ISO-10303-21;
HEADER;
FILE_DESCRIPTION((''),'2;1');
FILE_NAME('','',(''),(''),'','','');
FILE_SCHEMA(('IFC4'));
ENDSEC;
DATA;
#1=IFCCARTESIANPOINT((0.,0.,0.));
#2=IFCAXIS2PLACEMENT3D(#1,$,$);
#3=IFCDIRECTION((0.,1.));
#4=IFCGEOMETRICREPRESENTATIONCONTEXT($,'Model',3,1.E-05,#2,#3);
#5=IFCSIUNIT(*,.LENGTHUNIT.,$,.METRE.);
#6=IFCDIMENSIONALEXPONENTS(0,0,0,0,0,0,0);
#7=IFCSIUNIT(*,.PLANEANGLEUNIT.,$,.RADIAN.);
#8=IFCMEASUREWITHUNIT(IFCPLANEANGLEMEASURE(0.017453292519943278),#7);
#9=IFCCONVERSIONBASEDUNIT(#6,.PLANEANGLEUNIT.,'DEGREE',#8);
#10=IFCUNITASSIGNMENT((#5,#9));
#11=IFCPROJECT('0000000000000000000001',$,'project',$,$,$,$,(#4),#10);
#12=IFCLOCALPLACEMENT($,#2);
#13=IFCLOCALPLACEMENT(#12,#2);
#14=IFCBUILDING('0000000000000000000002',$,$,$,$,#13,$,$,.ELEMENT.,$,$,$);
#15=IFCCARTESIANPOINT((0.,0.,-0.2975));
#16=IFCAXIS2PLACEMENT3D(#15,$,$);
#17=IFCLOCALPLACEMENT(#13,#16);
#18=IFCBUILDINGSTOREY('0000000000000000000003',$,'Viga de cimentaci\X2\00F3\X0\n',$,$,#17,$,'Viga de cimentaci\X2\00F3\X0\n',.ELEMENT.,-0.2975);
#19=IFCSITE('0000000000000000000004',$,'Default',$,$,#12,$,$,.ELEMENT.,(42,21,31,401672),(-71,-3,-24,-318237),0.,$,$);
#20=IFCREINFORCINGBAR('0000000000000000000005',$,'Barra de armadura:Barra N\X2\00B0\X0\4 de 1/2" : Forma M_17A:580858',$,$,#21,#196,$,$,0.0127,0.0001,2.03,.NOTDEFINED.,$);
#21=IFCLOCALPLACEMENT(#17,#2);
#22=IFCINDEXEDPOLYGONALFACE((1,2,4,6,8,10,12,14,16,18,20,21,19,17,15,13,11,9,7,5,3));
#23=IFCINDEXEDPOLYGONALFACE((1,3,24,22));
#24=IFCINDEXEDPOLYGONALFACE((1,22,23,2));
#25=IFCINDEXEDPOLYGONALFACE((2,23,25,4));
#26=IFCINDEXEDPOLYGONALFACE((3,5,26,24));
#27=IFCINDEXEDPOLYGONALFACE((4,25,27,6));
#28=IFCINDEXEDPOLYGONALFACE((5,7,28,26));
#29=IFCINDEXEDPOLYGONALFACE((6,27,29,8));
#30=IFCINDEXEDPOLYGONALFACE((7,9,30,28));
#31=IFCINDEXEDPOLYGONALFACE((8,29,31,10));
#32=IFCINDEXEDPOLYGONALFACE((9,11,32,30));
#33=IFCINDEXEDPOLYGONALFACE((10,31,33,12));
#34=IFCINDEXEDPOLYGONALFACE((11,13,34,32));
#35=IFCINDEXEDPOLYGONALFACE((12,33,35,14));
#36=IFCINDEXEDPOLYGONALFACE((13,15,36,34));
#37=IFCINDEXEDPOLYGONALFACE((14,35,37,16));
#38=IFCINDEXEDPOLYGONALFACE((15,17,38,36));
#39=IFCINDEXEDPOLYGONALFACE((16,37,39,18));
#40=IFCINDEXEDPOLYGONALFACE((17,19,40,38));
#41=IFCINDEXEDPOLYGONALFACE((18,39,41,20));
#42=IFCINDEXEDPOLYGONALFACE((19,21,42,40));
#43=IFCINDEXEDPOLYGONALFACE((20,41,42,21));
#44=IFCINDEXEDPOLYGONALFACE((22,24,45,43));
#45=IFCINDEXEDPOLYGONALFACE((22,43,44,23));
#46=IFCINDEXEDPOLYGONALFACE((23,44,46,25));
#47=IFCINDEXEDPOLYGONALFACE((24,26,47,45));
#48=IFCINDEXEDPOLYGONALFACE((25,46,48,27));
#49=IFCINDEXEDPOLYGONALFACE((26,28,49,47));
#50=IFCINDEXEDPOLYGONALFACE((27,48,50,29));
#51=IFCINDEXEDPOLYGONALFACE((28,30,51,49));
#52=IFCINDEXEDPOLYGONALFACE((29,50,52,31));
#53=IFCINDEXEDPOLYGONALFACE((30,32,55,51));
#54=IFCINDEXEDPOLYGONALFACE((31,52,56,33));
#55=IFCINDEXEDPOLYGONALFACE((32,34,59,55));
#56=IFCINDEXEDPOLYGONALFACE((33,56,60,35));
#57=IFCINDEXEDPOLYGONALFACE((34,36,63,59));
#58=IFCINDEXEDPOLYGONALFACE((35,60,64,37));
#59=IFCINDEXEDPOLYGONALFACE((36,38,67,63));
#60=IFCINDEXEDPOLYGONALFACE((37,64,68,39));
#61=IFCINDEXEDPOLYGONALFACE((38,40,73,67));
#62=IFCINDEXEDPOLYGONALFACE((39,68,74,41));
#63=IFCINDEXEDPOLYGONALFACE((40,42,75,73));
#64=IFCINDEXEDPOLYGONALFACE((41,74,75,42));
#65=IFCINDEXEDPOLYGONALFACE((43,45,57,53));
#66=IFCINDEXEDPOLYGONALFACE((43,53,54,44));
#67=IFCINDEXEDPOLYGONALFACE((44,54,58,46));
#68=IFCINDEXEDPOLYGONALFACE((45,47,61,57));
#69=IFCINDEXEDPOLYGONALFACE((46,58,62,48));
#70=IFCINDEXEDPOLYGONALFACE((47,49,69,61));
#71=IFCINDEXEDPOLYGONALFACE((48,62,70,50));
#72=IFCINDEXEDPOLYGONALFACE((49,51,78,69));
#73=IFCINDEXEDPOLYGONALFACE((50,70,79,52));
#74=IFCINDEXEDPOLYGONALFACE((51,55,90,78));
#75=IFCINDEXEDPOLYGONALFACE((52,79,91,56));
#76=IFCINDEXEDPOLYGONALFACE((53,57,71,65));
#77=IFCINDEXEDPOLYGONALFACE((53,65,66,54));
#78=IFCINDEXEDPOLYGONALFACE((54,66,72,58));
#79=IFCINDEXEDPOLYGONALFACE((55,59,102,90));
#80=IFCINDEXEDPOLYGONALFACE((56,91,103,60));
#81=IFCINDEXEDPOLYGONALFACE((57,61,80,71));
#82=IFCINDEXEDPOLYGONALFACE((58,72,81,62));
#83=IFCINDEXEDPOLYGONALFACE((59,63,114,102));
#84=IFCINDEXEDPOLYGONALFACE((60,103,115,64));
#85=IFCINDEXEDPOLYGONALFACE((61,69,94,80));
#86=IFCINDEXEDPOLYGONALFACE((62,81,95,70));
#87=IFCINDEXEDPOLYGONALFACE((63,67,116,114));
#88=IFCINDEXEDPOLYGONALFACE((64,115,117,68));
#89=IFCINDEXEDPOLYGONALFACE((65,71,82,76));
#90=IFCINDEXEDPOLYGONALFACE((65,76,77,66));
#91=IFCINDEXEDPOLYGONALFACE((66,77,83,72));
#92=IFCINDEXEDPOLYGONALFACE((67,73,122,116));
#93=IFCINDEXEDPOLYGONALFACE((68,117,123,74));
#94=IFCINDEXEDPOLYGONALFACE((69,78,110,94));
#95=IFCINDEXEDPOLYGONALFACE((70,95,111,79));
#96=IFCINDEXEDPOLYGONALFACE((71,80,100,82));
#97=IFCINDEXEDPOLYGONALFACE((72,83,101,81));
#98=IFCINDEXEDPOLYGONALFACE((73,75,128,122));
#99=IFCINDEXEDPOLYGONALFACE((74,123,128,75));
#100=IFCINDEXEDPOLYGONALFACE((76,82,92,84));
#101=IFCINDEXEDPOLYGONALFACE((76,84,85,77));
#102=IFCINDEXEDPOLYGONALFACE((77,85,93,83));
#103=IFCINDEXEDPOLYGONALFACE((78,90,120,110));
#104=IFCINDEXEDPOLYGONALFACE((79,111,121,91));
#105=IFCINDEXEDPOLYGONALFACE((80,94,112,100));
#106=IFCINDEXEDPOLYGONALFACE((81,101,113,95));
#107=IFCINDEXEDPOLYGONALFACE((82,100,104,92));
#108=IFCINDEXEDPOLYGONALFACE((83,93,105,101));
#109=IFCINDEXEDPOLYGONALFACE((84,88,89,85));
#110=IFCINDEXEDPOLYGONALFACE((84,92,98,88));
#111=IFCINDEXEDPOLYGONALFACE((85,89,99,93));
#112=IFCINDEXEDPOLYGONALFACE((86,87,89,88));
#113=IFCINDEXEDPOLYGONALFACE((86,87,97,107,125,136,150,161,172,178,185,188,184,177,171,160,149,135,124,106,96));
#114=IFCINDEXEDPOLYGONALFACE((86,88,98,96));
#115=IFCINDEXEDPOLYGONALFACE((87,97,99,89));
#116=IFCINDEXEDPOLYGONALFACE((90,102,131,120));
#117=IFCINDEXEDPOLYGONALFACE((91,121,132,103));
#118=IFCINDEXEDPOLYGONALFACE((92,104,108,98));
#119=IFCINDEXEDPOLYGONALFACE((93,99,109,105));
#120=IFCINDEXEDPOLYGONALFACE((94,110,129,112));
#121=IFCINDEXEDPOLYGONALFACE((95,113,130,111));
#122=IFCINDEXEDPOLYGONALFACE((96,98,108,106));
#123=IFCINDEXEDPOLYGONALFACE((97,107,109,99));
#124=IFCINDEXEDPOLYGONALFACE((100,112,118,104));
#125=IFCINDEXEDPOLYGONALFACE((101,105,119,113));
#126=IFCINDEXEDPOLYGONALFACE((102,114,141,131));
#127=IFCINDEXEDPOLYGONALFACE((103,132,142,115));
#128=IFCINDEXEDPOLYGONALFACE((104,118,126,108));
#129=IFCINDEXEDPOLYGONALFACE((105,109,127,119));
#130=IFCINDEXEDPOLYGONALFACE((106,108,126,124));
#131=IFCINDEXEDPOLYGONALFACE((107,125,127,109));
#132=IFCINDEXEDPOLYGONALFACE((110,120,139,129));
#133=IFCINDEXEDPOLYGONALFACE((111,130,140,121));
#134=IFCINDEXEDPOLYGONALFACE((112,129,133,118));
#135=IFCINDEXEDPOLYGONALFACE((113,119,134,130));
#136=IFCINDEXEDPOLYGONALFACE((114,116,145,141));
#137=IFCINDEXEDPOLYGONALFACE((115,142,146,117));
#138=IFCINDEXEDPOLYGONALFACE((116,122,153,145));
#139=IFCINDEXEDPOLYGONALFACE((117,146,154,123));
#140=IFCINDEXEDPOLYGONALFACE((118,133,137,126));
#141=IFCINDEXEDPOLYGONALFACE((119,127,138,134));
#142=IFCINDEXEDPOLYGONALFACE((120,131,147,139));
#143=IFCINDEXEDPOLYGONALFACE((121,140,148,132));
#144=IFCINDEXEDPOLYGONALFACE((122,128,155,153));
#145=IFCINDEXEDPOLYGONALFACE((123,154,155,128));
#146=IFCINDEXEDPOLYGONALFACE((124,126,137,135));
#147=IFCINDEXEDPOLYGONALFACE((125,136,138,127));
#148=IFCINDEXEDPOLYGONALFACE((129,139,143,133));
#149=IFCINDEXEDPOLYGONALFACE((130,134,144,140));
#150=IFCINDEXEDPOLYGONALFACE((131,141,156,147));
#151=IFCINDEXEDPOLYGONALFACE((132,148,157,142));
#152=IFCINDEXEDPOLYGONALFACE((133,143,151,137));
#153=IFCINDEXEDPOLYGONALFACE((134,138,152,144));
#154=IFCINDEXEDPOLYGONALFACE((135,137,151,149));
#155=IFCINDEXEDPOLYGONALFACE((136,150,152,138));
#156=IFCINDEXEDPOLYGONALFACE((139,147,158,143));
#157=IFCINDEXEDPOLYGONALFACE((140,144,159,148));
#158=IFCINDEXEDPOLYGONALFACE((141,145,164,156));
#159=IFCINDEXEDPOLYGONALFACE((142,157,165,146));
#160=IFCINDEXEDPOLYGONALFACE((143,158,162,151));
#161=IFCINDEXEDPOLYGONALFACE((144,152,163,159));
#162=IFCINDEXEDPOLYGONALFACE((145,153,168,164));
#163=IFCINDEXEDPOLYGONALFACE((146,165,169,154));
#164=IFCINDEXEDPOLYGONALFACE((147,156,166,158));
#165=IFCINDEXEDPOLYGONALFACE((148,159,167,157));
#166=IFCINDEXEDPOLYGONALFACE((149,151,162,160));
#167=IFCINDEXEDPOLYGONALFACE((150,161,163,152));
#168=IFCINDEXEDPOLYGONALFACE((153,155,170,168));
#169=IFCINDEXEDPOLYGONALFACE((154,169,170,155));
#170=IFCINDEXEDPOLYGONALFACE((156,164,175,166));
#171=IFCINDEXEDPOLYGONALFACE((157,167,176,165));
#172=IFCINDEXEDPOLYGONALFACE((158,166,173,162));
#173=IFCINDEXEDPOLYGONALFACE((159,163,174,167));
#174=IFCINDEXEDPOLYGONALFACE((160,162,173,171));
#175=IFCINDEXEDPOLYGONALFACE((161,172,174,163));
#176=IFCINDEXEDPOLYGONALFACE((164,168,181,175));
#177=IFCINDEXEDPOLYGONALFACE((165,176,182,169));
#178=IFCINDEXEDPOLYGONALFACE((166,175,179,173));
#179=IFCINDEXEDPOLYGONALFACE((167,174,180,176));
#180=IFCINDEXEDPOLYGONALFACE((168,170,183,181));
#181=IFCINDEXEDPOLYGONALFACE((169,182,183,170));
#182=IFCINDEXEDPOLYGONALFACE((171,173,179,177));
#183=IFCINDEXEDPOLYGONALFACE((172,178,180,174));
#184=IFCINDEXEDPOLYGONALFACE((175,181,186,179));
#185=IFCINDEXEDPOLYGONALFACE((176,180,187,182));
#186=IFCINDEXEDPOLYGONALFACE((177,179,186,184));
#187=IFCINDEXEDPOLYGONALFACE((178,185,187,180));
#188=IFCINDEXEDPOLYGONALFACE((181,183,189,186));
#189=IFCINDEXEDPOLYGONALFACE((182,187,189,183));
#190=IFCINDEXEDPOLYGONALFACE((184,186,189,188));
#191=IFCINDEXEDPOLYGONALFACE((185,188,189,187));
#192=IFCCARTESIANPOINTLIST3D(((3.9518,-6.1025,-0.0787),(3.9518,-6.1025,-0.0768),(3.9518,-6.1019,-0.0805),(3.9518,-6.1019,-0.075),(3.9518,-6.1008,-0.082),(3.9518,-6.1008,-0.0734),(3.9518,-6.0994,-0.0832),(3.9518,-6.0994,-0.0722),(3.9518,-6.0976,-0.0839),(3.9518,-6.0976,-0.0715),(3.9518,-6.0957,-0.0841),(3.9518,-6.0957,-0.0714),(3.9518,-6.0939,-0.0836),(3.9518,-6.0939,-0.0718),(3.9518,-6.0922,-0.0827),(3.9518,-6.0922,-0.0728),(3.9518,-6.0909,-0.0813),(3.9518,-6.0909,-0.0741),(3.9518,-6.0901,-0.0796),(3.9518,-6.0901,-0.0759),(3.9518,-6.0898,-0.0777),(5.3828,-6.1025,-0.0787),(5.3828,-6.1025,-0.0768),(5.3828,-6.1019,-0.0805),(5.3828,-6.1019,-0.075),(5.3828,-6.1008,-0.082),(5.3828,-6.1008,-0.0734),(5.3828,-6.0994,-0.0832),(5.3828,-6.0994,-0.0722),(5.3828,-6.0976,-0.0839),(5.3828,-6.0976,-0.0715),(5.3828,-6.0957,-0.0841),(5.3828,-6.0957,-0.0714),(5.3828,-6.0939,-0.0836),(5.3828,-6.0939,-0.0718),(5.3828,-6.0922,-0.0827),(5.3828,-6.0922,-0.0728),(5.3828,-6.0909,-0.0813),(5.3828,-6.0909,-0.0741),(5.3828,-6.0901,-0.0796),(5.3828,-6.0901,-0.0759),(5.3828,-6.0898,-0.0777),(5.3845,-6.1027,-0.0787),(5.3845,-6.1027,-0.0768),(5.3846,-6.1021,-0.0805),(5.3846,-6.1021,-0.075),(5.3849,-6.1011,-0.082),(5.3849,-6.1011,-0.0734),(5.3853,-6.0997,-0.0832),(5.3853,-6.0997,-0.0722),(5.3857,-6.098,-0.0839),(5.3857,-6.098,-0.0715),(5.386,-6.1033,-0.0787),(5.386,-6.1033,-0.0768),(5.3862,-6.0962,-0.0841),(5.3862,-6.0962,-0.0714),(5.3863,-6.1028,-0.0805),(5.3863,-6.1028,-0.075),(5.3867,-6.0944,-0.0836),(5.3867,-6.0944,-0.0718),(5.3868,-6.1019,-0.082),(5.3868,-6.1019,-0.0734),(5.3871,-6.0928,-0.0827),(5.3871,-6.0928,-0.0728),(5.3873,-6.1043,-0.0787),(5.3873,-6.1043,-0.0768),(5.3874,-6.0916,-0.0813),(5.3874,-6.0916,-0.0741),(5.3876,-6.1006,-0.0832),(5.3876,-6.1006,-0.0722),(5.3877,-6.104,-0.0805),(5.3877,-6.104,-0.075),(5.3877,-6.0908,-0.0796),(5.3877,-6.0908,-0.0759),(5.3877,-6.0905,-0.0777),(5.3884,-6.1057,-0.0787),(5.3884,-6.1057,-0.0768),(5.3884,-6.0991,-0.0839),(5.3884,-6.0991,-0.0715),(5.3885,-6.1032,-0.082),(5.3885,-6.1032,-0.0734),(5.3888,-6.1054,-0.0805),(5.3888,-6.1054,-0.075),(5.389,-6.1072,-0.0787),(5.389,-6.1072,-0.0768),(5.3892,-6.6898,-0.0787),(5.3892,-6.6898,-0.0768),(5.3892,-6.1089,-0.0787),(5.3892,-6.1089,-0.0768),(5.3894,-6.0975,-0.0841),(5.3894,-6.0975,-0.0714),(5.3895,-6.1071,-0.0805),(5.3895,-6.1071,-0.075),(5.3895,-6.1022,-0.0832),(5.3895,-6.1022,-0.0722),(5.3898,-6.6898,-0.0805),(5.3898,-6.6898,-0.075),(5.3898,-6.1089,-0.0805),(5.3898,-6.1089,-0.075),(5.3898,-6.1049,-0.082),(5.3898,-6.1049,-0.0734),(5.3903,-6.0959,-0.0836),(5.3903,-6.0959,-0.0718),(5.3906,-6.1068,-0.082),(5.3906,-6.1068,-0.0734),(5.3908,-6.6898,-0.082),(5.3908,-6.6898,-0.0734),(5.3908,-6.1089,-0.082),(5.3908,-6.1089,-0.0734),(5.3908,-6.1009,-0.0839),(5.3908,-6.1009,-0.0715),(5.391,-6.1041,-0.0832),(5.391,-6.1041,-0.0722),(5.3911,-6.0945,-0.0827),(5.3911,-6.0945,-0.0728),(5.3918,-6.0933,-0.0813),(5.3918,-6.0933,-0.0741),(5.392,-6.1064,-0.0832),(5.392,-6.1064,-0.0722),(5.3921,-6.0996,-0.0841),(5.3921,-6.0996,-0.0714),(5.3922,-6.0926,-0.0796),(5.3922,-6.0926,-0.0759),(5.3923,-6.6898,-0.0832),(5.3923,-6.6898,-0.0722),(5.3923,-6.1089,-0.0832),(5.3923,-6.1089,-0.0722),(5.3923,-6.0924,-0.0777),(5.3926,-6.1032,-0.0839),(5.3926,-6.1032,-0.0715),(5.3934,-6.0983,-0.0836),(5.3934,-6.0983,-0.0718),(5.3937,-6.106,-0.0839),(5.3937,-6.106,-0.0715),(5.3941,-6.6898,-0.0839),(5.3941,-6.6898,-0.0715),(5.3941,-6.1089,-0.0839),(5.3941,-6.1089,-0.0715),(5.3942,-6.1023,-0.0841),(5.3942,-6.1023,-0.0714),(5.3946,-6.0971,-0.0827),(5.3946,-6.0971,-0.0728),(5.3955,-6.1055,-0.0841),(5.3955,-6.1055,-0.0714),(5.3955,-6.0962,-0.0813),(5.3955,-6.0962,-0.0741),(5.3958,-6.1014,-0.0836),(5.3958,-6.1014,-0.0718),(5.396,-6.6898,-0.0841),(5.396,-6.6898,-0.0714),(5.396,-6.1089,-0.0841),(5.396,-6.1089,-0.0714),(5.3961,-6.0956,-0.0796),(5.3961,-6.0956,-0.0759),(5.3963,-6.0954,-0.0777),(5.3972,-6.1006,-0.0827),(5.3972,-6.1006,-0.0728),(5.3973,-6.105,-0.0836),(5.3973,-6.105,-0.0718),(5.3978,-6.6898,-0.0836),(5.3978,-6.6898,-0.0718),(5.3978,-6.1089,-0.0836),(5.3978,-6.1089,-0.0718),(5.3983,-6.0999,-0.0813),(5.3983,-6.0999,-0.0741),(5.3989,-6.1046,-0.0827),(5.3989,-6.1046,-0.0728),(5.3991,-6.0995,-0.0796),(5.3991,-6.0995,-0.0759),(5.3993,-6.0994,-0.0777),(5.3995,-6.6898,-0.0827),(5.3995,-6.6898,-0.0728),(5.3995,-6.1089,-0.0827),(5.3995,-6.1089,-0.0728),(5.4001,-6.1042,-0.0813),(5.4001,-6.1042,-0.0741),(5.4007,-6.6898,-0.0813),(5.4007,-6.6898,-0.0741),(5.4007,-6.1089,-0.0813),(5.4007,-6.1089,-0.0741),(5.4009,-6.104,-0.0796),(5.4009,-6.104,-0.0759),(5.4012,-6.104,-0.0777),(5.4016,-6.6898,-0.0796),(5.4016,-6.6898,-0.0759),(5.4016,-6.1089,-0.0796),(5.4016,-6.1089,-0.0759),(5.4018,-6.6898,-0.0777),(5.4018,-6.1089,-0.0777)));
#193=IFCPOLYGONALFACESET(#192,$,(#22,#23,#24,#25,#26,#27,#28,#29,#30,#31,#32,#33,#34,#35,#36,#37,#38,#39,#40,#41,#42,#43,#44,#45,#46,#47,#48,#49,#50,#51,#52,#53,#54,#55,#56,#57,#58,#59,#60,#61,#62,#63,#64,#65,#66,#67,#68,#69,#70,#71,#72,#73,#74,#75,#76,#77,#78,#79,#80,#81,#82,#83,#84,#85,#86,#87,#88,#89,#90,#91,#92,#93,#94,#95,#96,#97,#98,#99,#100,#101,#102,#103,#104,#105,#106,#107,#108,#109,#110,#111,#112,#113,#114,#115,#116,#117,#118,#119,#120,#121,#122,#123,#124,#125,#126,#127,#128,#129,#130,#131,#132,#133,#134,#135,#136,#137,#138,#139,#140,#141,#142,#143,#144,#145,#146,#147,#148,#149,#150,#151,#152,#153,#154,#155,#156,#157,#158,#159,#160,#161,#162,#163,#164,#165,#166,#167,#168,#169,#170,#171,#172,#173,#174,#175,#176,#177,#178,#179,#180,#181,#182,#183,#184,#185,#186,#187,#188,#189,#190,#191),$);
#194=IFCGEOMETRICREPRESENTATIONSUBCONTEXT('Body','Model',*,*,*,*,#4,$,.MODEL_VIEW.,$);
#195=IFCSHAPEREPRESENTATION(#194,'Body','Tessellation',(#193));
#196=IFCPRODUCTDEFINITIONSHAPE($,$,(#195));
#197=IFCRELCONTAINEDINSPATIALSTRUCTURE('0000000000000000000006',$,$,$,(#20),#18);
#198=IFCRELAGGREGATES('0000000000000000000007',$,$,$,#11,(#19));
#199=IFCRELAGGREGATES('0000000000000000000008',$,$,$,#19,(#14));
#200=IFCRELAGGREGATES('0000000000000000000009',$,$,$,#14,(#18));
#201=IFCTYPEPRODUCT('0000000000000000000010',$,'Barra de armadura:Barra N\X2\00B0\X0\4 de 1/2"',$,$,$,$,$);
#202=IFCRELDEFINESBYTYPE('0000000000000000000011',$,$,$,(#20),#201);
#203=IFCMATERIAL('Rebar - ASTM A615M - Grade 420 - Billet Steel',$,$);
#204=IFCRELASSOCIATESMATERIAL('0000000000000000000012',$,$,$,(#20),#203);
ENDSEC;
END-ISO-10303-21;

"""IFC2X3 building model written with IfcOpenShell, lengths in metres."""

from ifc_helpers import new_model, entity, si_unit, converted_unit, direction, frame, origin, place, context, subcontext, project, spatial, material, type_object, element, save


model = new_model("IFC2X3")

# Units and contexts
model_context = context("Model", 3, precision=1e-05, world=origin(), true_north=direction((0.0, 1.0)))
body_context = subcontext(model_context, "Body", "Model", "MODEL_VIEW")
ifc_project = project(units=[si_unit("LENGTHUNIT", "METRE"), converted_unit("PLANEANGLEUNIT", "DEGREE", entity("IfcPlaneAngleMeasure", 0.017453292519943278), si_unit("PLANEANGLEUNIT", "RADIAN"), dimensions=[0, 0, 0, 0, 0, 0, 0])], contexts=[model_context])

# Site, building, storey
site_placement = place(None, origin())
site = spatial("IfcSite", under=ifc_project, at=site_placement, Name="Default", CompositionType="ELEMENT", RefLatitude=(42, 21, 31, 401672), RefLongitude=(-71, -3, -24, -318237), RefElevation=0.0)
building_placement = place(site_placement, origin())
building = spatial("IfcBuilding", under=site, at=building_placement, CompositionType="ELEMENT")
storey_placement = place(building_placement, frame((0.0, 0.0, -0.2975)))
storey = spatial("IfcBuildingStorey", under=building, at=storey_placement, Name="Viga de cimentación", LongName="Viga de cimentación", CompositionType="ELEMENT", Elevation=-0.2975)

# Reinforcing bar
ifc_material = material(Name="Rebar - ASTM A615M - Grade 420 - Billet Steel")
type_product_1 = type_object("IfcTypeProduct", Name="Barra de armadura:Barra N°4 de 1/2\"")
reinforcing_bar_1_placement = place(storey_placement, origin())
element("IfcReinforcingBar", 1, at=reinforcing_bar_1_placement, inside=storey, type_object=type_product_1, material=ifc_material, Name="Barra de armadura:Barra N°4 de 1/2\" : Forma M_17A:580858", BarLength=2.03, BarRole="NOTDEFINED", CrossSectionArea=0.0001, NominalDiameter=0.0127, context=body_context, shape_type="AdvancedSweptSolid", body=[
    entity("IfcSweptDiskSolid", entity("IfcCompositeCurve", [entity("IfcCompositeCurveSegment", "CONTINUOUS", True, entity("IfcPolyline", [entity("IfcCartesianPoint", [5.3955, -6.6898, -0.0777]), entity("IfcCartesianPoint", [5.3955, -6.1089, -0.0777])])), entity("IfcCompositeCurveSegment", "CONTINUOUS", True, entity("IfcTrimmedCurve", entity("IfcCircle", entity("IfcAxis2Placement3D", entity("IfcCartesianPoint", [5.3828, -6.1089, -0.0777]), entity("IfcDirection", [0.0, 0.0, 1.0]), entity("IfcDirection", [0.0, 1.0, 0.0])), 0.0127), [entity("IfcParameterValue", 270.0)], [entity("IfcParameterValue", 360.0)], True, "PARAMETER")), entity("IfcCompositeCurveSegment", "CONTINUOUS", True, entity("IfcPolyline", [entity("IfcCartesianPoint", [5.3828, -6.0962, -0.0777]), entity("IfcCartesianPoint", [3.9518, -6.0962, -0.0777])]))], False), 0.0063, None, 0.0, 92.0),
])

save(model, "model.ifc")
